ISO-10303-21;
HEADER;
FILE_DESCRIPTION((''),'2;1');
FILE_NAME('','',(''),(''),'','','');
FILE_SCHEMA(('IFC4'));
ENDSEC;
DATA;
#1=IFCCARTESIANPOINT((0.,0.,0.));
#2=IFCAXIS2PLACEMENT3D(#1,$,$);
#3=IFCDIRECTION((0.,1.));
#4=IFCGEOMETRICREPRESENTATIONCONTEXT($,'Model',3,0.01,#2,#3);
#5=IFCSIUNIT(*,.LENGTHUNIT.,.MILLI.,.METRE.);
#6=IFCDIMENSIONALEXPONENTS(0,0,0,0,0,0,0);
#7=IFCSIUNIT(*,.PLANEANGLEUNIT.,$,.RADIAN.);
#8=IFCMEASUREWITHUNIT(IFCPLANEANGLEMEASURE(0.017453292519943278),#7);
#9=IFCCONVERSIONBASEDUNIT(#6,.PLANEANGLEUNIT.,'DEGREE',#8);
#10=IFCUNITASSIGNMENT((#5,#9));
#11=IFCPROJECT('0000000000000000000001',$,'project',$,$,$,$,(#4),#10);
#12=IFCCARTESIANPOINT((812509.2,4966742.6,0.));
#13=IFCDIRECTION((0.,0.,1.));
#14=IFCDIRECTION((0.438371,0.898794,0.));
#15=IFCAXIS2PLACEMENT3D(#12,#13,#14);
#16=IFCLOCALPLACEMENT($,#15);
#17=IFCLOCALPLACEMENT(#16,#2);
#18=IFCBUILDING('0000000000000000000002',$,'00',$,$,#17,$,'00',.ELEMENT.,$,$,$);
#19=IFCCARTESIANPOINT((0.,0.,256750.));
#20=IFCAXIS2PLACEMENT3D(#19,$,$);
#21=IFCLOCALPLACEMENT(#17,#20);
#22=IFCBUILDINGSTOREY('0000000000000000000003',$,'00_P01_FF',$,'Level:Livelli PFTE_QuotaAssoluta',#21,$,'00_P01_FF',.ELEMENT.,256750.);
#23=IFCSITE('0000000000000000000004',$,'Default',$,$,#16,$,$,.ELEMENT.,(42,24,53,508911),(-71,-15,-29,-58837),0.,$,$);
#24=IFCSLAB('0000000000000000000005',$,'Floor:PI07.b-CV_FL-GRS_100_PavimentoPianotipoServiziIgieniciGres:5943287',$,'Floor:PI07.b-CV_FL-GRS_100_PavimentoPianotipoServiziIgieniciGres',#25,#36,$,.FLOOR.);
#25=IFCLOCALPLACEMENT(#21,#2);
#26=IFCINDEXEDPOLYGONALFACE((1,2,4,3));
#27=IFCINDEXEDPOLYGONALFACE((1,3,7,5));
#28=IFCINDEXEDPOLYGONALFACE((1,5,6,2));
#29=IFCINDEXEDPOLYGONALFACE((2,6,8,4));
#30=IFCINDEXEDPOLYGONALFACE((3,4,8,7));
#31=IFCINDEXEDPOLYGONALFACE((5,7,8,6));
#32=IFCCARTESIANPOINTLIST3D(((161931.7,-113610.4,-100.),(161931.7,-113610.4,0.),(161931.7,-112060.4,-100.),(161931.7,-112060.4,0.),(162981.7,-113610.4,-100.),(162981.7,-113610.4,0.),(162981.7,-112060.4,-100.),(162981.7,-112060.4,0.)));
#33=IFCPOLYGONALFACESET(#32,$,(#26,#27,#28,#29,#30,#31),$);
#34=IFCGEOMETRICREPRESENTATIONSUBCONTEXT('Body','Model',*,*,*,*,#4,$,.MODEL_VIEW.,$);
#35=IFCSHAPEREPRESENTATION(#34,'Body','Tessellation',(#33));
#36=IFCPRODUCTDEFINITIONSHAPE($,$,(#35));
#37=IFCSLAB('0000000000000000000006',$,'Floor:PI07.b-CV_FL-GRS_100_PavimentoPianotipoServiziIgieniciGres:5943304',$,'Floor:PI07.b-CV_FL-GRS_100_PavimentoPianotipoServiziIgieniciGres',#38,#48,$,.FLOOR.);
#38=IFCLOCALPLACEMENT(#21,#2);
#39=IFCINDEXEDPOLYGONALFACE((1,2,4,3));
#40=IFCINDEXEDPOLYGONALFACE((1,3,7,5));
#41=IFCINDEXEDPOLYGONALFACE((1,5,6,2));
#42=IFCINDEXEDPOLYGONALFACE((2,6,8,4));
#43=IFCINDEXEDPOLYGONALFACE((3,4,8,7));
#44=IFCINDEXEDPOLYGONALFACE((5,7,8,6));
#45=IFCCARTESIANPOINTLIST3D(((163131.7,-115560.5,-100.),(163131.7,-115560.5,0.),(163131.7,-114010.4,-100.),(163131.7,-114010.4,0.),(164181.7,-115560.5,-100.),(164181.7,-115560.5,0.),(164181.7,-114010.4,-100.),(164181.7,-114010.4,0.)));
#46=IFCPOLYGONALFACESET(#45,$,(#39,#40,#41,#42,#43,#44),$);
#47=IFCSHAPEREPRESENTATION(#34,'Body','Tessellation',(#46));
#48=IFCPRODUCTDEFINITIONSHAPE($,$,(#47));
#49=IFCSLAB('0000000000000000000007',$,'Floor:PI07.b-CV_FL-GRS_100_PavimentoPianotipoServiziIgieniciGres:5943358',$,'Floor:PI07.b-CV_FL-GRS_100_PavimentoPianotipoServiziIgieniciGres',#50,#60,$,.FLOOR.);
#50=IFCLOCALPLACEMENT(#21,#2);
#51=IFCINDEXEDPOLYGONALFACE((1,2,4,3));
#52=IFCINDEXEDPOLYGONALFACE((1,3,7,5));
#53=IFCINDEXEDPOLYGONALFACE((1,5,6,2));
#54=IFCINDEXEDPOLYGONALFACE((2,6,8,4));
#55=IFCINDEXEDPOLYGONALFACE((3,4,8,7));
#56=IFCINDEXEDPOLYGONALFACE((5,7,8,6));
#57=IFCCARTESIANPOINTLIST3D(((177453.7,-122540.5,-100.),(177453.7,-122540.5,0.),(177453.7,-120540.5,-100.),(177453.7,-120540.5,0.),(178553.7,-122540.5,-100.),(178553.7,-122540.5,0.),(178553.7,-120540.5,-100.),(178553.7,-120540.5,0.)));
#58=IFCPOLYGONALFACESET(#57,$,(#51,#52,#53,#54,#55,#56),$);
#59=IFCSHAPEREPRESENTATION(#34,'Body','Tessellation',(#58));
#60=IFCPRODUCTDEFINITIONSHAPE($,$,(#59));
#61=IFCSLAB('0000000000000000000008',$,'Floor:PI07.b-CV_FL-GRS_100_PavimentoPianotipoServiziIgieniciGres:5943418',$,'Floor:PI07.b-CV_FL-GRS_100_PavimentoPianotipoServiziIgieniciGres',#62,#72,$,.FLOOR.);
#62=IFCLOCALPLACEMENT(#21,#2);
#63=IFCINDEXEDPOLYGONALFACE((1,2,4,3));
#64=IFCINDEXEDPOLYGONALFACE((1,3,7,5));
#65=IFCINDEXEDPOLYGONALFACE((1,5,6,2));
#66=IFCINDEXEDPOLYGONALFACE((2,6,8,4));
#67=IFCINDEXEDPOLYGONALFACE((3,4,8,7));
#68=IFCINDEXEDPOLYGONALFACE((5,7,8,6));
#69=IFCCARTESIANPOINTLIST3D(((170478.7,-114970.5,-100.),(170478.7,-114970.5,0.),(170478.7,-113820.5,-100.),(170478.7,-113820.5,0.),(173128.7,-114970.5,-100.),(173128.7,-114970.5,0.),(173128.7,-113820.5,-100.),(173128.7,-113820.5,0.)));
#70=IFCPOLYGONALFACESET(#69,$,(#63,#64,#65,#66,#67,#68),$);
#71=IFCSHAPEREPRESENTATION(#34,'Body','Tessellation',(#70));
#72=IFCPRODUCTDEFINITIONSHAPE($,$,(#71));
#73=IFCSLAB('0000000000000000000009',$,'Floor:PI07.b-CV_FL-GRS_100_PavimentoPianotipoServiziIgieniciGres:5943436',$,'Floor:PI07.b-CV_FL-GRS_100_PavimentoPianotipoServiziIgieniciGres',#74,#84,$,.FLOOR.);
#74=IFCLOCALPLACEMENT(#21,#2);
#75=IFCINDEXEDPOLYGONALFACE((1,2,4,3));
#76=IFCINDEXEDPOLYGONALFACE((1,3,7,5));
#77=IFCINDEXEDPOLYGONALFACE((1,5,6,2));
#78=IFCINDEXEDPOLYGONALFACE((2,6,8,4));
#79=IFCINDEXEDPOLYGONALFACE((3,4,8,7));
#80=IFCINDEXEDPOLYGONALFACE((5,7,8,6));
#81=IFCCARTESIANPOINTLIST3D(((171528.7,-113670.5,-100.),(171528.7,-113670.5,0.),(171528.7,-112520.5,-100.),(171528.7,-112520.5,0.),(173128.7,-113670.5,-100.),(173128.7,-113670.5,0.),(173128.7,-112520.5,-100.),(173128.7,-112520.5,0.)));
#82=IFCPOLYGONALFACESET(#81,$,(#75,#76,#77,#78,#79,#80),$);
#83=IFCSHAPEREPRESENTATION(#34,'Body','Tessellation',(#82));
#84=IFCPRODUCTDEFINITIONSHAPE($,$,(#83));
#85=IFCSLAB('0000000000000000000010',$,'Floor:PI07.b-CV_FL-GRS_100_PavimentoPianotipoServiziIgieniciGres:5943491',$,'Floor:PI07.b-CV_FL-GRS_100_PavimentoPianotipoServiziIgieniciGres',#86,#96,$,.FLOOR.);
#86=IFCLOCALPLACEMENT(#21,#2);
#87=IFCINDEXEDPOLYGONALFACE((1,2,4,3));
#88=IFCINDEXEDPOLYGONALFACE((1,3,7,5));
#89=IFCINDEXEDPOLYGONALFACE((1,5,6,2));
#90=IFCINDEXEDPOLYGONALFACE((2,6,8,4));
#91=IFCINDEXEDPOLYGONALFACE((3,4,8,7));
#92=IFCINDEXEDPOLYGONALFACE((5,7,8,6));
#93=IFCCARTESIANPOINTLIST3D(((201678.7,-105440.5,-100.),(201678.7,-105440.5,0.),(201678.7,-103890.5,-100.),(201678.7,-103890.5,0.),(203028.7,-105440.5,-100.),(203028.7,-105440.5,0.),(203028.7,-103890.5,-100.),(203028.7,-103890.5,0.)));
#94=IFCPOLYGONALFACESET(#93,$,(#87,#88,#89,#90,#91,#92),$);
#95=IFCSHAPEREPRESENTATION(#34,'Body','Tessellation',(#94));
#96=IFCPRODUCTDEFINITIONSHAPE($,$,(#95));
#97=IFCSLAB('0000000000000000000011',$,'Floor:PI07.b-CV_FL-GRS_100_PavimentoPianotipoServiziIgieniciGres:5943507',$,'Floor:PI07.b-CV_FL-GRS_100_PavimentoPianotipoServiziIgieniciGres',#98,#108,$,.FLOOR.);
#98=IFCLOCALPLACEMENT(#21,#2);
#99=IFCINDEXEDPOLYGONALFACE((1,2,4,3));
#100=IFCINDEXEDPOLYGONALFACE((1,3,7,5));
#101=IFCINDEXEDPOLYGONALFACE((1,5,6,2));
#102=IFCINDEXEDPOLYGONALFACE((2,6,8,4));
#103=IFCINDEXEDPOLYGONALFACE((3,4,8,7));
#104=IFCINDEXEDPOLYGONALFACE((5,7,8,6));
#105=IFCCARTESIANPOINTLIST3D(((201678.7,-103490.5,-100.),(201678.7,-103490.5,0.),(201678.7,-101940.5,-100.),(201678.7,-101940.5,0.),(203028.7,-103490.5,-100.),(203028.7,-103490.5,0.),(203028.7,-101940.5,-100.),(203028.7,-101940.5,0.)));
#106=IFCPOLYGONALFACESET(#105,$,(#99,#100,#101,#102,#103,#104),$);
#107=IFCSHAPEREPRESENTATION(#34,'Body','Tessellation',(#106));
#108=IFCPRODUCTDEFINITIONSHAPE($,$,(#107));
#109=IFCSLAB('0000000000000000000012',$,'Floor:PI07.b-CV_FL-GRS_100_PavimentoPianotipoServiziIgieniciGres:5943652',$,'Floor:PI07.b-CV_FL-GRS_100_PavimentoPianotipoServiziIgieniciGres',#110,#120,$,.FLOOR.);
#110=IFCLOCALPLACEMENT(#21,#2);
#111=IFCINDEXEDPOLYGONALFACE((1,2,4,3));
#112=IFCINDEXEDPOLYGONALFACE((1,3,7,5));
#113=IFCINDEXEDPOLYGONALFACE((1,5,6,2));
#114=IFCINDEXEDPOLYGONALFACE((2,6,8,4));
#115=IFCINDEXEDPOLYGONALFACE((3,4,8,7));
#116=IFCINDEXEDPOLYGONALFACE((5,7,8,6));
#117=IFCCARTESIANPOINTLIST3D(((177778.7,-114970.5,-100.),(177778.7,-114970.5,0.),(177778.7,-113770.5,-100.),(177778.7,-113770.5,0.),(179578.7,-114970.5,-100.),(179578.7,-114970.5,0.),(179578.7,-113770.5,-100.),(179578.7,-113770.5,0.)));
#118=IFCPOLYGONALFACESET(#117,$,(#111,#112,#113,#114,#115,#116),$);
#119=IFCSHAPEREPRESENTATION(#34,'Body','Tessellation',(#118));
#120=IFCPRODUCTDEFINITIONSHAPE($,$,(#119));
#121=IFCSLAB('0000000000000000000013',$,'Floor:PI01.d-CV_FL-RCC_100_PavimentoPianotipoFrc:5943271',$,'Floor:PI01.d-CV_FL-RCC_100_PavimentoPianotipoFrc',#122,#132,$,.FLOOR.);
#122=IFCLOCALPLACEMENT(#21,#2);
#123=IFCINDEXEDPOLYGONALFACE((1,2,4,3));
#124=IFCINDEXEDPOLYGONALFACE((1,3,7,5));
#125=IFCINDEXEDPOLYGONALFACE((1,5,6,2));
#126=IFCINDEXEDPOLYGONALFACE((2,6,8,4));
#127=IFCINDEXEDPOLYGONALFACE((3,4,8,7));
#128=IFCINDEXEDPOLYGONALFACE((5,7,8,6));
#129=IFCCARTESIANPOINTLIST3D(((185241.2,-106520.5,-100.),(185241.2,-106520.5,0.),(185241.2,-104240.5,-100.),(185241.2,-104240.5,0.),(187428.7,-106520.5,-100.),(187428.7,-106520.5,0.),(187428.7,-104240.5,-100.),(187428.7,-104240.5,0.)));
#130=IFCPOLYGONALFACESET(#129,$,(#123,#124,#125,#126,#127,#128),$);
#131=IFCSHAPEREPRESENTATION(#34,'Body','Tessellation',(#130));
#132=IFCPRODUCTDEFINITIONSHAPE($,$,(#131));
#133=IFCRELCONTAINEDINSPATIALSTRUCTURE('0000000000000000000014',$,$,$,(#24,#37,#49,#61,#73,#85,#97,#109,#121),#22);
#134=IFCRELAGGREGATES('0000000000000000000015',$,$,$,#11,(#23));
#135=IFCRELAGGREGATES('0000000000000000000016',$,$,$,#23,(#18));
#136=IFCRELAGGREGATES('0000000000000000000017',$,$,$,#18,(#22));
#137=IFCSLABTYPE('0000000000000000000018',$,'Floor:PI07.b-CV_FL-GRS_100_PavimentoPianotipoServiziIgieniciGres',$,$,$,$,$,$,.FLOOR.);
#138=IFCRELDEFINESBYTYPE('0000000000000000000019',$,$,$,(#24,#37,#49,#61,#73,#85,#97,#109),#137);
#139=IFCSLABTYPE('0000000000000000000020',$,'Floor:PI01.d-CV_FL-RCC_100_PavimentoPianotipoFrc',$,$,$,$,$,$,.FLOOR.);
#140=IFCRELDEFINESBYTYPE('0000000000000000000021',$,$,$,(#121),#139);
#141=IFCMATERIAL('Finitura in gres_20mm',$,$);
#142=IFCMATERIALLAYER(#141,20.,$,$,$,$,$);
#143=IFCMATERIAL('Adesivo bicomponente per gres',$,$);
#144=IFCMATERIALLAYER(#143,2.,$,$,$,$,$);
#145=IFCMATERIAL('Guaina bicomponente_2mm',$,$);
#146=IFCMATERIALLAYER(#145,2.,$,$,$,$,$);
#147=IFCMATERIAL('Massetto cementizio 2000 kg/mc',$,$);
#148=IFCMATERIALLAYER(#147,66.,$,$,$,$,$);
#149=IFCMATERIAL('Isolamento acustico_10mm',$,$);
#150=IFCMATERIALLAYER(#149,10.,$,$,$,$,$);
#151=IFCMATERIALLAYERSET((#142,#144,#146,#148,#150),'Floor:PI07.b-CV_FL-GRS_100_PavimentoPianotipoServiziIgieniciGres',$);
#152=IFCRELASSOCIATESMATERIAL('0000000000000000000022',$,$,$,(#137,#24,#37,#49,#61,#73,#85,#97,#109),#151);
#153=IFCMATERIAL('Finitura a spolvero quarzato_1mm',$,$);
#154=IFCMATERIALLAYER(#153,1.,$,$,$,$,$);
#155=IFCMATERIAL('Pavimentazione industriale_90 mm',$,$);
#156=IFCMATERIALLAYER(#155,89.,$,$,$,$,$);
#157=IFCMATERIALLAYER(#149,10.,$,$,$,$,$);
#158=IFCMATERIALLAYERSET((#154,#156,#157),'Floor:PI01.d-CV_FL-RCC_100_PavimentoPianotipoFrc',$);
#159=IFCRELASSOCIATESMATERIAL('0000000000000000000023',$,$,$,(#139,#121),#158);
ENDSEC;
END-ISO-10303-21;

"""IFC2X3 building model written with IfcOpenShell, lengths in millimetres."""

from ifc_helpers import new_model, entity, si_unit, converted_unit, direction, frame, frame_2d, origin, origin_2d_with_axis, place, context, subcontext, project, spatial, rectangle, extrude, material, layer, layer_set, layer_usage, type_object, element, save


model = new_model("IFC2X3")

# Units and contexts
model_context = context("Model", 3, precision=0.01, world=origin(), true_north=direction((0.0, 1.0)))
body_context = subcontext(model_context, "Body", "Model", "MODEL_VIEW")
ifc_project = project(units=[si_unit("LENGTHUNIT", "METRE", prefix="MILLI"), converted_unit("PLANEANGLEUNIT", "DEGREE", entity("IfcPlaneAngleMeasure", 0.017453292519943278), si_unit("PLANEANGLEUNIT", "RADIAN"), dimensions=[0, 0, 0, 0, 0, 0, 0])], contexts=[model_context])

# Site, building, storey
site_placement = place(None, frame((812509.2, 4966742.6, 0.0), z_axis=(0.0, 0.0, 1.0), x_axis=(0.438371, 0.898794, 0.0)))
site = spatial("IfcSite", under=ifc_project, at=site_placement, Name="Default", CompositionType="ELEMENT", RefLatitude=(42, 24, 53, 508911), RefLongitude=(-71, -15, -29, -58837), RefElevation=0.0)
building_placement = place(site_placement, origin())
building = spatial("IfcBuilding", under=site, at=building_placement, Name="00", LongName="00", CompositionType="ELEMENT")
storey_placement = place(building_placement, frame((0.0, 0.0, 256750.0)))
storey = spatial("IfcBuildingStorey", under=building, at=storey_placement, Name="00_P01_FF", ObjectType="Level:Livelli PFTE_QuotaAssoluta", LongName="00_P01_FF", CompositionType="ELEMENT", Elevation=256750.0)

# Slabs
ifc_material_1 = material(Name="Massetto cementizio 2000 kg/mc")
ifc_material_2 = material(Name="Isolamento acustico_10mm")
ifc_material_3 = material(Name="Finitura in gres_20mm")
ifc_layer_1 = layer(ifc_material_3, 20.0)
ifc_material_4 = material(Name="Adesivo bicomponente per gres")
ifc_layer_2 = layer(ifc_material_4, 2.0)
ifc_material_5 = material(Name="Guaina bicomponente_2mm")
ifc_layer_3 = layer(ifc_material_5, 2.0)
ifc_layer_4 = layer(ifc_material_1, 66.0)
ifc_layer_5 = layer(ifc_material_2, 10.0)
ifc_layer_set_1 = layer_set([ifc_layer_1, ifc_layer_2, ifc_layer_3, ifc_layer_4, ifc_layer_5], Name="Floor:PI07.b-CV_FL-GRS_100_PavimentoPianotipoServiziIgieniciGres")
ifc_layer_usage_1 = layer_usage(ifc_layer_set_1, "AXIS3", "POSITIVE", 0.0)
slab_type_1 = type_object("IfcSlabType", Name="Floor:PI07.b-CV_FL-GRS_100_PavimentoPianotipoServiziIgieniciGres", PredefinedType="FLOOR", material=ifc_layer_set_1)
slab_1_placement = place(storey_placement, origin())
element("IfcSlab", 1, at=slab_1_placement, inside=storey, type_object=slab_type_1, material=ifc_layer_usage_1, Name="Floor:PI07.b-CV_FL-GRS_100_PavimentoPianotipoServiziIgieniciGres:5943287", ObjectType="Floor:PI07.b-CV_FL-GRS_100_PavimentoPianotipoServiziIgieniciGres", PredefinedType="FLOOR", context=body_context, shape_type="SweptSolid", body=[
    extrude(rectangle(XDim=1050.0, YDim=1550.0, at=origin_2d_with_axis()), frame((162456.7, -112835.4, 0.0), z_axis=(0.0, 0.0, -1.0), x_axis=(1.0, 0.0, 0.0)), (0.0, 0.0, 1.0), 100.0),
])
ifc_layer_usage_2 = layer_usage(ifc_layer_set_1, "AXIS3", "POSITIVE", 0.0)
slab_2_placement = place(storey_placement, origin())
element("IfcSlab", 2, at=slab_2_placement, inside=storey, type_object=slab_type_1, material=ifc_layer_usage_2, Name="Floor:PI07.b-CV_FL-GRS_100_PavimentoPianotipoServiziIgieniciGres:5943304", ObjectType="Floor:PI07.b-CV_FL-GRS_100_PavimentoPianotipoServiziIgieniciGres", PredefinedType="FLOOR", context=body_context, shape_type="SweptSolid", body=[
    extrude(rectangle(XDim=1550.1, YDim=1050.0, at=origin_2d_with_axis()), frame((163656.7, -114785.4, 0.0), z_axis=(0.0, 0.0, -1.0), x_axis=(0.0, 1.0, 0.0)), (0.0, 0.0, 1.0), 100.0),
])
ifc_layer_usage_3 = layer_usage(ifc_layer_set_1, "AXIS3", "POSITIVE", 0.0)
slab_3_placement = place(storey_placement, origin())
element("IfcSlab", 3, at=slab_3_placement, inside=storey, type_object=slab_type_1, material=ifc_layer_usage_3, Name="Floor:PI07.b-CV_FL-GRS_100_PavimentoPianotipoServiziIgieniciGres:5943358", ObjectType="Floor:PI07.b-CV_FL-GRS_100_PavimentoPianotipoServiziIgieniciGres", PredefinedType="FLOOR", context=body_context, shape_type="SweptSolid", body=[
    extrude(rectangle(XDim=2000.0, YDim=1100.0, at=frame_2d((0.0, 0.0), x_axis=(1.0, 0.0))), frame((178003.7, -121540.5, 0.0), z_axis=(0.0, 0.0, -1.0), x_axis=(0.0, 1.0, 0.0)), (0.0, 0.0, 1.0), 100.0),
])
ifc_layer_usage_4 = layer_usage(ifc_layer_set_1, "AXIS3", "POSITIVE", 0.0)
slab_4_placement = place(storey_placement, origin())
element("IfcSlab", 4, at=slab_4_placement, inside=storey, type_object=slab_type_1, material=ifc_layer_usage_4, Name="Floor:PI07.b-CV_FL-GRS_100_PavimentoPianotipoServiziIgieniciGres:5943418", ObjectType="Floor:PI07.b-CV_FL-GRS_100_PavimentoPianotipoServiziIgieniciGres", PredefinedType="FLOOR", context=body_context, shape_type="SweptSolid", body=[
    extrude(rectangle(XDim=1150.0, YDim=2650.0, at=frame_2d((0.0, 0.0), x_axis=(1.0, 0.0))), frame((171803.7, -114395.5, 0.0), z_axis=(0.0, 0.0, -1.0), x_axis=(0.0, 1.0, 0.0)), (0.0, 0.0, 1.0), 100.0),
])
ifc_layer_usage_5 = layer_usage(ifc_layer_set_1, "AXIS3", "POSITIVE", 0.0)
slab_5_placement = place(storey_placement, origin())
element("IfcSlab", 5, at=slab_5_placement, inside=storey, type_object=slab_type_1, material=ifc_layer_usage_5, Name="Floor:PI07.b-CV_FL-GRS_100_PavimentoPianotipoServiziIgieniciGres:5943436", ObjectType="Floor:PI07.b-CV_FL-GRS_100_PavimentoPianotipoServiziIgieniciGres", PredefinedType="FLOOR", context=body_context, shape_type="SweptSolid", body=[
    extrude(rectangle(XDim=1150.0, YDim=1600.0, at=frame_2d((0.0, 0.0), x_axis=(1.0, 0.0))), frame((172328.7, -113095.5, 0.0), z_axis=(0.0, 0.0, -1.0), x_axis=(0.0, 1.0, 0.0)), (0.0, 0.0, 1.0), 100.0),
])
ifc_layer_usage_6 = layer_usage(ifc_layer_set_1, "AXIS3", "POSITIVE", 0.0)
slab_6_placement = place(storey_placement, origin())
element("IfcSlab", 6, at=slab_6_placement, inside=storey, type_object=slab_type_1, material=ifc_layer_usage_6, Name="Floor:PI07.b-CV_FL-GRS_100_PavimentoPianotipoServiziIgieniciGres:5943491", ObjectType="Floor:PI07.b-CV_FL-GRS_100_PavimentoPianotipoServiziIgieniciGres", PredefinedType="FLOOR", context=body_context, shape_type="SweptSolid", body=[
    extrude(rectangle(XDim=1550.0, YDim=1350.0, at=origin_2d_with_axis()), frame((202353.7, -104665.5, 0.0), z_axis=(0.0, 0.0, -1.0), x_axis=(0.0, 1.0, 0.0)), (0.0, 0.0, 1.0), 100.0),
])
ifc_layer_usage_7 = layer_usage(ifc_layer_set_1, "AXIS3", "POSITIVE", 0.0)
slab_7_placement = place(storey_placement, origin())
element("IfcSlab", 7, at=slab_7_placement, inside=storey, type_object=slab_type_1, material=ifc_layer_usage_7, Name="Floor:PI07.b-CV_FL-GRS_100_PavimentoPianotipoServiziIgieniciGres:5943507", ObjectType="Floor:PI07.b-CV_FL-GRS_100_PavimentoPianotipoServiziIgieniciGres", PredefinedType="FLOOR", context=body_context, shape_type="SweptSolid", body=[
    extrude(rectangle(XDim=1550.0, YDim=1350.0, at=origin_2d_with_axis()), frame((202353.7, -102715.5, 0.0), z_axis=(0.0, 0.0, -1.0), x_axis=(0.0, 1.0, 0.0)), (0.0, 0.0, 1.0), 100.0),
])
ifc_layer_usage_8 = layer_usage(ifc_layer_set_1, "AXIS3", "POSITIVE", 0.0)
slab_8_placement = place(storey_placement, origin())
element("IfcSlab", 8, at=slab_8_placement, inside=storey, type_object=slab_type_1, material=ifc_layer_usage_8, Name="Floor:PI07.b-CV_FL-GRS_100_PavimentoPianotipoServiziIgieniciGres:5943652", ObjectType="Floor:PI07.b-CV_FL-GRS_100_PavimentoPianotipoServiziIgieniciGres", PredefinedType="FLOOR", context=body_context, shape_type="SweptSolid", body=[
    extrude(rectangle(XDim=1200.0, YDim=1800.0, at=frame_2d((0.0, 0.0), x_axis=(1.0, 0.0))), frame((178678.7, -114370.5, 0.0), z_axis=(0.0, 0.0, -1.0), x_axis=(0.0, 1.0, 0.0)), (0.0, 0.0, 1.0), 100.0),
])
ifc_material_6 = material(Name="Finitura a spolvero quarzato_1mm")
ifc_layer_6 = layer(ifc_material_6, 1.0)
ifc_material_7 = material(Name="Pavimentazione industriale_90 mm")
ifc_layer_7 = layer(ifc_material_7, 89.0)
ifc_layer_8 = layer(ifc_material_2, 10.0)
ifc_layer_set_2 = layer_set([ifc_layer_6, ifc_layer_7, ifc_layer_8], Name="Floor:PI01.d-CV_FL-RCC_100_PavimentoPianotipoFrc")
ifc_layer_usage_9 = layer_usage(ifc_layer_set_2, "AXIS3", "POSITIVE", 0.0)
slab_type_2 = type_object("IfcSlabType", Name="Floor:PI01.d-CV_FL-RCC_100_PavimentoPianotipoFrc", PredefinedType="FLOOR", material=ifc_layer_set_2)
slab_9_placement = place(storey_placement, origin())
element("IfcSlab", 9, at=slab_9_placement, inside=storey, type_object=slab_type_2, material=ifc_layer_usage_9, Name="Floor:PI01.d-CV_FL-RCC_100_PavimentoPianotipoFrc:5943271", ObjectType="Floor:PI01.d-CV_FL-RCC_100_PavimentoPianotipoFrc", PredefinedType="FLOOR", context=body_context, shape_type="SweptSolid", body=[
    extrude(rectangle(XDim=2280.0, YDim=2187.5, at=frame_2d((0.0, 0.0), x_axis=(1.0, 0.0))), frame((186334.9, -105380.5, 0.0), z_axis=(0.0, 0.0, -1.0), x_axis=(0.0, 1.0, 0.0)), (0.0, 0.0, 1.0), 100.0),
])

save(model, "model.ifc")
